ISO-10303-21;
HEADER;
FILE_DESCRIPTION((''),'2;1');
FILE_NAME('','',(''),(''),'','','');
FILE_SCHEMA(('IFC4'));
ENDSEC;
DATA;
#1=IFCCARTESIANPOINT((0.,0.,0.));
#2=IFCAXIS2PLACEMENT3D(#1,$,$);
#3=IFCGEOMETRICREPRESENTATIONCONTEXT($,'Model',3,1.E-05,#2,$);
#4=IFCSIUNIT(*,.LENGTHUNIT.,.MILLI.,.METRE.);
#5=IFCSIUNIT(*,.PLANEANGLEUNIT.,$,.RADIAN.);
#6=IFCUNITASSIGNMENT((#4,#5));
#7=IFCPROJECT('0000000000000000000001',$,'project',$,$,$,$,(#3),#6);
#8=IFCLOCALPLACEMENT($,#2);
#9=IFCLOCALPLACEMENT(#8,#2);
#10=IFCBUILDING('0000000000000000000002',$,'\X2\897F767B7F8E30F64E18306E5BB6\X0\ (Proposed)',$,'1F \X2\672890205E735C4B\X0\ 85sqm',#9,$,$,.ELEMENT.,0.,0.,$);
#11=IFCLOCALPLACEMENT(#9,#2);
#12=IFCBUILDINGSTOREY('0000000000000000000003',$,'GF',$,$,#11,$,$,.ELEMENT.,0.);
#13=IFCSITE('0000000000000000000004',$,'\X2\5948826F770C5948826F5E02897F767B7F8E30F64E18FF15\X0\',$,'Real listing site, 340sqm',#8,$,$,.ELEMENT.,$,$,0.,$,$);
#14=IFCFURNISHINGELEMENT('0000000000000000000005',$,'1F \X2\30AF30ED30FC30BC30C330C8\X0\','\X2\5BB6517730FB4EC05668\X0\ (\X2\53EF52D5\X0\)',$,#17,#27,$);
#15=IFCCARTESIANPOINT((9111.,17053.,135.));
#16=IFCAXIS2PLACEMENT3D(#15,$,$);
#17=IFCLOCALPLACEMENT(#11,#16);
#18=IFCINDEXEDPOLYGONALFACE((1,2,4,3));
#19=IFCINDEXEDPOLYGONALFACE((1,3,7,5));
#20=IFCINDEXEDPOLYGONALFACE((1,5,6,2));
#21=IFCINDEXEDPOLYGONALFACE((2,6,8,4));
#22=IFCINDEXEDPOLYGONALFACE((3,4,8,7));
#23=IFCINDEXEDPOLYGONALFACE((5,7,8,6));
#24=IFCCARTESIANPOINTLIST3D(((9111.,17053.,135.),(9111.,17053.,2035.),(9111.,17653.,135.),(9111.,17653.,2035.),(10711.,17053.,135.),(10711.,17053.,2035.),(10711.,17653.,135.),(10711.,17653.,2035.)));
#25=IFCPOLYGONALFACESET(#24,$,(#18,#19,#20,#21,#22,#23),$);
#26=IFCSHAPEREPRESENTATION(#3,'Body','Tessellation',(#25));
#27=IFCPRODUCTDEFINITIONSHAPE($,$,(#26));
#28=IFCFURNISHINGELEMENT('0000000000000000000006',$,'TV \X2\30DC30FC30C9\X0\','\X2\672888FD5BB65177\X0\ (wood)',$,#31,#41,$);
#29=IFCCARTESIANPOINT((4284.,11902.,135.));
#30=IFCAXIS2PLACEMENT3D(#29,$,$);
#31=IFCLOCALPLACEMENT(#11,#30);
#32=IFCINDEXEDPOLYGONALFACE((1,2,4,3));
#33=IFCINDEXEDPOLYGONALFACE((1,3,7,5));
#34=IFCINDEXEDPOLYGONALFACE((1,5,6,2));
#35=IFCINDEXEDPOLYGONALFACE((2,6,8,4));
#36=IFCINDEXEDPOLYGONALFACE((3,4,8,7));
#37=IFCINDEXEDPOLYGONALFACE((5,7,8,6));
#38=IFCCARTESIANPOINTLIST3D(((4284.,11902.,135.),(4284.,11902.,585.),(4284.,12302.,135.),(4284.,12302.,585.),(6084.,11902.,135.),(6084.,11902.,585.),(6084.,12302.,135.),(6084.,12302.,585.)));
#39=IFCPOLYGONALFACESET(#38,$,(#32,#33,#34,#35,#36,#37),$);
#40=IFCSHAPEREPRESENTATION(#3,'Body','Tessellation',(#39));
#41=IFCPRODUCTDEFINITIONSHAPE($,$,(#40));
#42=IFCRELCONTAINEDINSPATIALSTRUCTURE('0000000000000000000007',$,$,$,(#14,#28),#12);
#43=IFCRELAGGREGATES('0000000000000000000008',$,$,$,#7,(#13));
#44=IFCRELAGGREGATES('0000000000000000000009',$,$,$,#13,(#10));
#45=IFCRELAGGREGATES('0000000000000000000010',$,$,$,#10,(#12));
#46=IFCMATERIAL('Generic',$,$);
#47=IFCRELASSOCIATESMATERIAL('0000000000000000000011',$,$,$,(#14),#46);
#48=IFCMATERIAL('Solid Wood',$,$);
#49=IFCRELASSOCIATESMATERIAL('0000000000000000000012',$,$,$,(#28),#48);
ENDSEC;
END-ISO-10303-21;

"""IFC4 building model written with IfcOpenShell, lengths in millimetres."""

from ifc_helpers import new_model, si_unit, frame, frame_2d, origin, place, context, project, spatial, rectangle, extrude, material, element, save


model = new_model("IFC4")

# Units and contexts
model_context = context("Model", 3, precision=1e-05, world=origin())
ifc_project = project(units=[si_unit("LENGTHUNIT", "METRE", prefix="MILLI"), si_unit("PLANEANGLEUNIT", "RADIAN")], contexts=[model_context])

# Site, building, storey
site_placement = place(None, origin())
site = spatial("IfcSite", under=ifc_project, at=site_placement, Name="奈良県奈良市西登美ヶ丘５", ObjectType="Real listing site, 340sqm", CompositionType="ELEMENT", RefElevation=0.0)
building_placement = place(site_placement, origin())
building = spatial("IfcBuilding", under=site, at=building_placement, Name="西登美ヶ丘の家 (Proposed)", ObjectType="1F 木造平屋 85sqm", CompositionType="ELEMENT", ElevationOfRefHeight=0.0, ElevationOfTerrain=0.0)
storey_placement = place(building_placement, origin())
storey = spatial("IfcBuildingStorey", under=building, at=storey_placement, Name="GF", CompositionType="ELEMENT", Elevation=0.0)

# Shared definitions
ifc_material_1 = material(Name="Solid Wood")

# Shared definitions
ifc_material_2 = material(Name="Generic")

# Furnishing elements
furnishing_1_placement = place(storey_placement, frame((9111.0, 17053.0, 135.0)))
element("IfcFurnishingElement", 1, at=furnishing_1_placement, inside=storey, material=ifc_material_2, Name="1F クローゼット", Description="家具・什器 (可動)", context=model_context, shape_type="SweptSolid", body=[
    extrude(rectangle(XDim=1600.0, YDim=600.0, at=frame_2d((800.0, 300.0))), frame((9111.0, 17053.0, 135.0)), (0.0, 0.0, 1.0), 1900.0),
])
furnishing_2_placement = place(storey_placement, frame((4284.0, 11902.0, 135.0)))
element("IfcFurnishingElement", 2, at=furnishing_2_placement, inside=storey, material=ifc_material_1, Name="TV ボード", Description="木製家具 (wood)", context=model_context, shape_type="SweptSolid", body=[
    extrude(rectangle(XDim=1800.0, YDim=400.0, at=frame_2d((900.0, 200.0))), frame((4284.0, 11902.0, 135.0)), (0.0, 0.0, 1.0), 450.0),
])

save(model, "model.ifc")
